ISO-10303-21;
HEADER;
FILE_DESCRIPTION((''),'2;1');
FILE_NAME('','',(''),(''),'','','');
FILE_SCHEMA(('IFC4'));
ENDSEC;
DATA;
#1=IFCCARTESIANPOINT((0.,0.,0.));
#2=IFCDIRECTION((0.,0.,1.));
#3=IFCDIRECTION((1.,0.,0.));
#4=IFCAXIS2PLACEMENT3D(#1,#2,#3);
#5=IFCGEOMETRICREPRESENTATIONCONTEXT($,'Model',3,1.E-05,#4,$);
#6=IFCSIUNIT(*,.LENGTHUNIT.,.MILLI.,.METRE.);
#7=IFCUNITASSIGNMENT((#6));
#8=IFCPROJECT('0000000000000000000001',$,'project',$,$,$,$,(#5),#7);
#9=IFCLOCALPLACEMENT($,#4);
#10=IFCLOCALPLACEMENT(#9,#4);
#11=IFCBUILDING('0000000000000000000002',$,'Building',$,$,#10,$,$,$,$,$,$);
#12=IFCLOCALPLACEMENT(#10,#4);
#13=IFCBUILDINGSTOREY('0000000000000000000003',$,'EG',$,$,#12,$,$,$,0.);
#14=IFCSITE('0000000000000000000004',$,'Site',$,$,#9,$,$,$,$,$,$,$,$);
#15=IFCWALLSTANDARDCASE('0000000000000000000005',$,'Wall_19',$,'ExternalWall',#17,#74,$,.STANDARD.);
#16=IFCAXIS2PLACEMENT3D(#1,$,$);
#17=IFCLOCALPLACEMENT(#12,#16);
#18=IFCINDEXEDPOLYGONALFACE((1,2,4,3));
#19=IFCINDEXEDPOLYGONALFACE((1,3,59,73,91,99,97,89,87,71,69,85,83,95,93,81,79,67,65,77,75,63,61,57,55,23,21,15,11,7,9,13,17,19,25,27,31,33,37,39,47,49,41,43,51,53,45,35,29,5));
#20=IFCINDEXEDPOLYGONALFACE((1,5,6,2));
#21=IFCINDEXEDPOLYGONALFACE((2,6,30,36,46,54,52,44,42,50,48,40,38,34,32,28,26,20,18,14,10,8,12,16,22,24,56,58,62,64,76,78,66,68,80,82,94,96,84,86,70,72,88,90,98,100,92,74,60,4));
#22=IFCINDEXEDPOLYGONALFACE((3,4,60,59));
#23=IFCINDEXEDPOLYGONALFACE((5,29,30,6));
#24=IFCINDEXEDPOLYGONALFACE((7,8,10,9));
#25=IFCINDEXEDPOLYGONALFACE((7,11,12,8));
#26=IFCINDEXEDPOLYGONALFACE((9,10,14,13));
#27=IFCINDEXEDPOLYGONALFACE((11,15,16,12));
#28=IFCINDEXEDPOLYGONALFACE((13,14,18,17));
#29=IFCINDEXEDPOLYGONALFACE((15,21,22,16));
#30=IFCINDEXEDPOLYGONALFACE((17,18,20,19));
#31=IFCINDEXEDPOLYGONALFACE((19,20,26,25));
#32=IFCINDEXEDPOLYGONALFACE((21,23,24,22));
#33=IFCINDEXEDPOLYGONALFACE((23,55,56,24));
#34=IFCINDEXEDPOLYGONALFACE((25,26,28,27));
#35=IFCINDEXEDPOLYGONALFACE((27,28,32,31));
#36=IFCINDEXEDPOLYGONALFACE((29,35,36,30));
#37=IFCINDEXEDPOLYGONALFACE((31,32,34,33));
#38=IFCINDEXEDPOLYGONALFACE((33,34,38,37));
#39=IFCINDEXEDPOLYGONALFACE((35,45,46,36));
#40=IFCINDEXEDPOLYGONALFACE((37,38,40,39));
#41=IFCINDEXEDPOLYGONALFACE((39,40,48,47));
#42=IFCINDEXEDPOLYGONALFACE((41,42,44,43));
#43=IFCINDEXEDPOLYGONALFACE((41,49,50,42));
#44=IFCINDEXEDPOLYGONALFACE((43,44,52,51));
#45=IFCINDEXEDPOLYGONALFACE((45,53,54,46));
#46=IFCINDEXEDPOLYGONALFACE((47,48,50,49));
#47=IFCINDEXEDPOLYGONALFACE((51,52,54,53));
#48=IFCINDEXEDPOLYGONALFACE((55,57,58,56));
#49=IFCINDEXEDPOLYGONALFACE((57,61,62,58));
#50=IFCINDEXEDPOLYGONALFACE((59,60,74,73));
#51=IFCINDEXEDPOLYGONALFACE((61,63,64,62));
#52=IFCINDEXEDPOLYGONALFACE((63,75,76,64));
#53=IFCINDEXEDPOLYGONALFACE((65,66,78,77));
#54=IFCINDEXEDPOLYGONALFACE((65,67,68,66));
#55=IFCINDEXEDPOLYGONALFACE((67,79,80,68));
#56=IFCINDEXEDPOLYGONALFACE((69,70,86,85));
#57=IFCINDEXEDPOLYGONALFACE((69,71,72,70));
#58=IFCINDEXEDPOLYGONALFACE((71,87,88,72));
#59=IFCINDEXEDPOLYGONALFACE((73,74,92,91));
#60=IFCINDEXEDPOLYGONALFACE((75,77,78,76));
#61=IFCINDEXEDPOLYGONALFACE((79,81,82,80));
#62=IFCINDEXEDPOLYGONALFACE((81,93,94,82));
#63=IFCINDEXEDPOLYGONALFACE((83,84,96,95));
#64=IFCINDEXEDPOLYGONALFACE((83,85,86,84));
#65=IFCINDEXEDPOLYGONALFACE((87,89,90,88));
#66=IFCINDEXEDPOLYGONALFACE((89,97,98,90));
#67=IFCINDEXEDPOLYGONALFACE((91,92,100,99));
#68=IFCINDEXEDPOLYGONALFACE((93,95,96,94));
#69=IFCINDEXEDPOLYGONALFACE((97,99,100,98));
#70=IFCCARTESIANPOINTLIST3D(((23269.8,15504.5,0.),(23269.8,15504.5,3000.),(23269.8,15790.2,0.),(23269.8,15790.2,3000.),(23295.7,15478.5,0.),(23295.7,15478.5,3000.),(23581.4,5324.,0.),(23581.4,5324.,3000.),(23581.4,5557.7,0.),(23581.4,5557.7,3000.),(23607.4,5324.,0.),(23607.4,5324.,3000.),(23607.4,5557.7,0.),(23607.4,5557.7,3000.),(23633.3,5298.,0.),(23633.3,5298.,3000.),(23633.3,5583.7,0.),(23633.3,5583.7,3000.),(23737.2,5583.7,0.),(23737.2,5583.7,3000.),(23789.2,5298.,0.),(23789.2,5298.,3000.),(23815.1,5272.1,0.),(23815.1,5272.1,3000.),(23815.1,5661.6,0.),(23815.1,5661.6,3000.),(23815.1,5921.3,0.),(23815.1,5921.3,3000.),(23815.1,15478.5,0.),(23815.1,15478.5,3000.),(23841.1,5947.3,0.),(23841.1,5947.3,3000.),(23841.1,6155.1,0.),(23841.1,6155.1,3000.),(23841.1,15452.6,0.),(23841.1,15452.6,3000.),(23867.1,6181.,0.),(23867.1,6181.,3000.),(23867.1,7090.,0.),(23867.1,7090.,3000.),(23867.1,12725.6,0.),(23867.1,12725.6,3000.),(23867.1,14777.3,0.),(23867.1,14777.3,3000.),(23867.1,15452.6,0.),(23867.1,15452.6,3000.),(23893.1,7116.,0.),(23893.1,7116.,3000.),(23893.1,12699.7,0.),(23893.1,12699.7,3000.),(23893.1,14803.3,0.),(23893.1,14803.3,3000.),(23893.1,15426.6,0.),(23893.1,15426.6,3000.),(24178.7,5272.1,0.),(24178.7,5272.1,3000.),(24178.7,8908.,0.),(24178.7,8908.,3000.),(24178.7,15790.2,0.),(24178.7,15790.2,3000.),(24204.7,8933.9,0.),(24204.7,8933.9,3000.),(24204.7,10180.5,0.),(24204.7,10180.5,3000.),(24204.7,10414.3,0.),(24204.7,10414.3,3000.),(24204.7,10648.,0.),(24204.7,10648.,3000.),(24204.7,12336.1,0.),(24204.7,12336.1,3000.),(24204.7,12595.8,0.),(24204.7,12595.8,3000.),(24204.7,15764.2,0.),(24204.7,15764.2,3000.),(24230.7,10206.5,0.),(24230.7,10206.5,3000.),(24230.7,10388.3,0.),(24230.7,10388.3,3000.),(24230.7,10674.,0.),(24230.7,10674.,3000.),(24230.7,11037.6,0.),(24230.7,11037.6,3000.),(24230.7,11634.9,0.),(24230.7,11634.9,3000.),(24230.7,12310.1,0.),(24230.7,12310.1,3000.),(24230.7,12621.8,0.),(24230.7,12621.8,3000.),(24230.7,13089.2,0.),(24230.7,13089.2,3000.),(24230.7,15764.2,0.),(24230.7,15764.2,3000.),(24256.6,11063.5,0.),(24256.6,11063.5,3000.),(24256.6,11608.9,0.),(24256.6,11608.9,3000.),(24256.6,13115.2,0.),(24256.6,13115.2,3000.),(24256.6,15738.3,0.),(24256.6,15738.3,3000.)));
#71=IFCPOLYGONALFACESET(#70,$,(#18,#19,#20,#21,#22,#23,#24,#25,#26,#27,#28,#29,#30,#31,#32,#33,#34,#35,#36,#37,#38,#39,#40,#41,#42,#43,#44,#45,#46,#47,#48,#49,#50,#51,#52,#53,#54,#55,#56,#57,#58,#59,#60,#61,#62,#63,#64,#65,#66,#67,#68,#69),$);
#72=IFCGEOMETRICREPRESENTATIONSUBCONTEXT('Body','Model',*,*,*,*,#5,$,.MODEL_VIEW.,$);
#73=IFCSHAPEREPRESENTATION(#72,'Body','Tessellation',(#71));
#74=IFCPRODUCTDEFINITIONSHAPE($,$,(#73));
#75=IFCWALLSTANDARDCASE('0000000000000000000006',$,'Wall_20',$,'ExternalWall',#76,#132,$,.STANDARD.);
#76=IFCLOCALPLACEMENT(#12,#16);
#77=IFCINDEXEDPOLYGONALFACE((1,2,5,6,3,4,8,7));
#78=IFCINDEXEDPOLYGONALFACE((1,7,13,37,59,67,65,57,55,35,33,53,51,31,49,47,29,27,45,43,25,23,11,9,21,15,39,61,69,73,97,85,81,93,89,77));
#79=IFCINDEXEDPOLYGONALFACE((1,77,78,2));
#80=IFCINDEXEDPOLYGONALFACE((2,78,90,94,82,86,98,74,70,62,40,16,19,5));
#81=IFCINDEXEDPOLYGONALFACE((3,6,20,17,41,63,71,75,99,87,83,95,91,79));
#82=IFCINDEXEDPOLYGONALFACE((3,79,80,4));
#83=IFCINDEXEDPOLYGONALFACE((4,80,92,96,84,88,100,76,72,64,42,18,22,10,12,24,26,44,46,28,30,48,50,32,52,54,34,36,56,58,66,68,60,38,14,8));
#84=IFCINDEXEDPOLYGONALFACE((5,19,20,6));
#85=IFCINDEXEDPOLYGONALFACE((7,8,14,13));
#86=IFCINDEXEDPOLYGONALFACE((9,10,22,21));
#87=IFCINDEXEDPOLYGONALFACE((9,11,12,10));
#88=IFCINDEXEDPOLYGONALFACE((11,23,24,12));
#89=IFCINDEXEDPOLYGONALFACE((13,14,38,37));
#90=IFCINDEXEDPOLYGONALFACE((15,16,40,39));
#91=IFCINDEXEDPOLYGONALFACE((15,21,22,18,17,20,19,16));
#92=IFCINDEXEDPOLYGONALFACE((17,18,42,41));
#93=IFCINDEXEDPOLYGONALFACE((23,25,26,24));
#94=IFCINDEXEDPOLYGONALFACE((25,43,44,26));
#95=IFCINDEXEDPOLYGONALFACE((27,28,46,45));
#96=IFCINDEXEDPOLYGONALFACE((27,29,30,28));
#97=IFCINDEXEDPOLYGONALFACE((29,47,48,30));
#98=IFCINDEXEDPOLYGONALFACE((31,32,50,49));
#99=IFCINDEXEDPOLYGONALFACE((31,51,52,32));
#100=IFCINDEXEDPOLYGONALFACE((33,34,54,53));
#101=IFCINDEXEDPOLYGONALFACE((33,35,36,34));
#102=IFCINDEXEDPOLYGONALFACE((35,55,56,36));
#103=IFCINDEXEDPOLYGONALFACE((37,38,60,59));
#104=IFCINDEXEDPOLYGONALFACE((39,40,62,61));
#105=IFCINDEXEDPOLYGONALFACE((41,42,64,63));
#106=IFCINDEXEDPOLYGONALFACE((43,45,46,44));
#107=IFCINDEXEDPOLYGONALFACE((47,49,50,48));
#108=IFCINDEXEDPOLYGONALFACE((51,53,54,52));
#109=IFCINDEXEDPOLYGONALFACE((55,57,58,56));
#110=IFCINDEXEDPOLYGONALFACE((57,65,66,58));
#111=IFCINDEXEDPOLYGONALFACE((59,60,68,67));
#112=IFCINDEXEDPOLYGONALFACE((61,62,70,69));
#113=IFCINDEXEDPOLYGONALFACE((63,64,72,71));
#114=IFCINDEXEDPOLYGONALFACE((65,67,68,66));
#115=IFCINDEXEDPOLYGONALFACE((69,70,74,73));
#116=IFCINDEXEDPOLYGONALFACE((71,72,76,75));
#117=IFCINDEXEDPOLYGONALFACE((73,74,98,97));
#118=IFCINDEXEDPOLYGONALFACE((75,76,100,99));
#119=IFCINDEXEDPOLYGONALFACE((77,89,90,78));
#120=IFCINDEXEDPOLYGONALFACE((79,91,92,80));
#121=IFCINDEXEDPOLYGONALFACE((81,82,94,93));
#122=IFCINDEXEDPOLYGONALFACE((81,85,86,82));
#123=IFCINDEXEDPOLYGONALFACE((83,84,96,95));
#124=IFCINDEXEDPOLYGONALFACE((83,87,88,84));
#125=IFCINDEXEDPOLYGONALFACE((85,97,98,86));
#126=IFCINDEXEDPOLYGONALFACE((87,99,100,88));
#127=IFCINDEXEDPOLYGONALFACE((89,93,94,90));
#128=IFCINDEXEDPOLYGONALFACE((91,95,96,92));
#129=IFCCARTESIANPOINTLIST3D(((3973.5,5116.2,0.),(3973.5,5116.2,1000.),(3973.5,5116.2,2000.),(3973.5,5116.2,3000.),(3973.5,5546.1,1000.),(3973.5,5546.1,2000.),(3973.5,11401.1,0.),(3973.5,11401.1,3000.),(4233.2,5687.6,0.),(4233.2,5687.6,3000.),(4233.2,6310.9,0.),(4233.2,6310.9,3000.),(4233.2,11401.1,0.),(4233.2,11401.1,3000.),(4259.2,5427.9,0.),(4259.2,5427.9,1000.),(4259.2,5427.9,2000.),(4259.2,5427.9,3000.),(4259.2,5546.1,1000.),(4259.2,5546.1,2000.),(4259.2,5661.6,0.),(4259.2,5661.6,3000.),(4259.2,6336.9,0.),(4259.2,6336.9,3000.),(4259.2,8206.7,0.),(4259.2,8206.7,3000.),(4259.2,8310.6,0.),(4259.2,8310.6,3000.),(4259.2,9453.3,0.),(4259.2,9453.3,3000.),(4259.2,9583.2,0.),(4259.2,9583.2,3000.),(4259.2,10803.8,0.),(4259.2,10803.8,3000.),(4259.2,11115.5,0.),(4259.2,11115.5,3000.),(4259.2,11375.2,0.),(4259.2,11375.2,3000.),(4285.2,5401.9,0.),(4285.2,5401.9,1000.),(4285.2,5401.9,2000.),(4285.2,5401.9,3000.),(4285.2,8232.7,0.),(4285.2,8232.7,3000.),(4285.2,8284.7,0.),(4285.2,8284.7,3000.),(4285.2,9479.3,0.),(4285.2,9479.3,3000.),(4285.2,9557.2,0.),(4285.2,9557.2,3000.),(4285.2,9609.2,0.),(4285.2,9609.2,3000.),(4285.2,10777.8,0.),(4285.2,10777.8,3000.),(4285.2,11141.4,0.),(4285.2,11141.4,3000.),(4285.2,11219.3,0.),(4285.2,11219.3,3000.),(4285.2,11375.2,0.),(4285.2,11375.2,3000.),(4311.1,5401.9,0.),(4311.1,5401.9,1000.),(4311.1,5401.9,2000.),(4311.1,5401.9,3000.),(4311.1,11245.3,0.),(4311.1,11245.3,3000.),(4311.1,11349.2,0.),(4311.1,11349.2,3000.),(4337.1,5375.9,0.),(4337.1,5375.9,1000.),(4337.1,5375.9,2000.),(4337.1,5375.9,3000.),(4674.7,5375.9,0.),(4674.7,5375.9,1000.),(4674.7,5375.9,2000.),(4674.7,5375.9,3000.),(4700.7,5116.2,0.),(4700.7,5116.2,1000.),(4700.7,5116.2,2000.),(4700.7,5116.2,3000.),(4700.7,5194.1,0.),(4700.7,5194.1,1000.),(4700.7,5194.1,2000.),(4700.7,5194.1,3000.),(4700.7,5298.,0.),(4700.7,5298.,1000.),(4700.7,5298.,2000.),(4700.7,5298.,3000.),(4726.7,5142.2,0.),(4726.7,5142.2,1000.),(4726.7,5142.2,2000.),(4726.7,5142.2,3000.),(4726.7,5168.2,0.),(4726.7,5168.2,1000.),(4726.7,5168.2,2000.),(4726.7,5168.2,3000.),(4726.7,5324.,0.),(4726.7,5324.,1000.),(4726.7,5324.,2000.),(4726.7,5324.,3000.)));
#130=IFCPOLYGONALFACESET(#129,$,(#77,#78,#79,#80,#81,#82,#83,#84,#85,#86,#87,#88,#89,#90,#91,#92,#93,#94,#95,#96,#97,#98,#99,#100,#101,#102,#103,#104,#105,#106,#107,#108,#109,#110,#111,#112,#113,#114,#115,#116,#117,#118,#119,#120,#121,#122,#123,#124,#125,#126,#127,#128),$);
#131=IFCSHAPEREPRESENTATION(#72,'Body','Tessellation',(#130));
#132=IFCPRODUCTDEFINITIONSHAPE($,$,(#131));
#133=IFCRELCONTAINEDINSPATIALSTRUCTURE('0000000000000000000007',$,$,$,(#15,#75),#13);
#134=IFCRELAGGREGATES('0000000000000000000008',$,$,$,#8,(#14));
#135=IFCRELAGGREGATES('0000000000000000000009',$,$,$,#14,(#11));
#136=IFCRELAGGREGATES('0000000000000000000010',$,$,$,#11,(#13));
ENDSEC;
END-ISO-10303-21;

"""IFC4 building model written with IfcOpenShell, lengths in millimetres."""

from ifc_helpers import new_model, si_unit, frame, origin_with_axes, place, context, subcontext, project, spatial, polyline, rectangle, outline, extrude, element, save


model = new_model("IFC4")

# Units and contexts
model_context = context("Model", 3, precision=1e-05, world=origin_with_axes())
body_context = subcontext(model_context, "Body", "Model", "MODEL_VIEW")
ifc_project = project(units=[si_unit("LENGTHUNIT", "METRE", prefix="MILLI")], contexts=[model_context])

# Site, building, storey
site_placement = place(None, origin_with_axes())
site = spatial("IfcSite", under=ifc_project, at=site_placement, Name="Site")
building_placement = place(site_placement, origin_with_axes())
building = spatial("IfcBuilding", under=site, at=building_placement, Name="Building")
storey_placement = place(building_placement, origin_with_axes())
storey = spatial("IfcBuildingStorey", under=building, at=storey_placement, Name="EG", Elevation=0.0)

# Wall
wall_1_placement = place(storey_placement, origin_with_axes())
element("IfcWallStandardCase", 1, at=wall_1_placement, inside=storey, Name="Wall_19", ObjectType="ExternalWall", PredefinedType="STANDARD", context=body_context, shape_type="SweptSolid", body=[
    extrude(outline(polyline([(23815.1, 5272.1, 0.0), (23789.2, 5298.0, 0.0), (23633.3, 5298.0, 0.0), (23607.4, 5324.0, 0.0), (23581.4, 5324.0, 0.0), (23581.4, 5557.7, 0.0), (23607.4, 5557.7, 0.0), (23633.3, 5583.7, 0.0), (23737.2, 5583.7, 0.0), (23815.1, 5661.6, 0.0), (23815.1, 5921.3, 0.0), (23841.1, 5947.3, 0.0), (23841.1, 6155.1, 0.0), (23867.1, 6181.0, 0.0), (23867.1, 7090.0, 0.0), (23893.1, 7116.0, 0.0), (23893.1, 12699.7, 0.0), (23867.1, 12725.6, 0.0), (23867.1, 14777.3, 0.0), (23893.1, 14803.3, 0.0), (23893.1, 15426.6, 0.0), (23867.1, 15452.6, 0.0), (23841.1, 15452.6, 0.0), (23815.1, 15478.5, 0.0), (23295.7, 15478.5, 0.0), (23269.8, 15504.5, 0.0), (23269.8, 15790.2, 0.0), (24178.7, 15790.2, 0.0), (24204.7, 15764.2, 0.0), (24230.7, 15764.2, 0.0), (24256.6, 15738.3, 0.0), (24256.6, 13115.2, 0.0), (24230.7, 13089.2, 0.0), (24230.7, 12621.8, 0.0), (24204.7, 12595.8, 0.0), (24204.7, 12336.1, 0.0), (24230.7, 12310.1, 0.0), (24230.7, 11634.9, 0.0), (24256.6, 11608.9, 0.0), (24256.6, 11063.5, 0.0), (24230.7, 11037.6, 0.0), (24230.7, 10674.0, 0.0), (24204.7, 10648.0, 0.0), (24204.7, 10414.3, 0.0), (24230.7, 10388.3, 0.0), (24230.7, 10206.5, 0.0), (24204.7, 10180.5, 0.0), (24204.7, 8933.9, 0.0), (24178.7, 8908.0, 0.0), (24178.7, 5272.1, 0.0), (23815.1, 5272.1, 0.0)])), origin_with_axes(), (0.0, 0.0, 1.0), 3000.0),
])

# Wall, opening
wall_2_placement = place(storey_placement, origin_with_axes())
wall_2 = element("IfcWallStandardCase", 2, at=wall_2_placement, inside=storey, Name="Wall_20", ObjectType="ExternalWall", PredefinedType="STANDARD", context=body_context, shape_type="SweptSolid", body=[
    extrude(outline(polyline([(3973.5, 5116.2, 0.0), (3973.5, 11401.1, 0.0), (4233.2, 11401.1, 0.0), (4259.2, 11375.2, 0.0), (4285.2, 11375.2, 0.0), (4311.1, 11349.2, 0.0), (4311.1, 11245.3, 0.0), (4285.2, 11219.3, 0.0), (4285.2, 11141.4, 0.0), (4259.2, 11115.5, 0.0), (4259.2, 10803.8, 0.0), (4285.2, 10777.8, 0.0), (4285.2, 9609.2, 0.0), (4259.2, 9583.2, 0.0), (4285.2, 9557.2, 0.0), (4285.2, 9479.3, 0.0), (4259.2, 9453.3, 0.0), (4259.2, 8310.6, 0.0), (4285.2, 8284.7, 0.0), (4285.2, 8232.7, 0.0), (4259.2, 8206.7, 0.0), (4259.2, 6336.9, 0.0), (4233.2, 6310.9, 0.0), (4233.2, 5687.6, 0.0), (4259.2, 5661.6, 0.0), (4259.2, 5427.9, 0.0), (4285.2, 5401.9, 0.0), (4311.1, 5401.9, 0.0), (4337.1, 5375.9, 0.0), (4674.7, 5375.9, 0.0), (4726.7, 5324.0, 0.0), (4700.7, 5298.0, 0.0), (4700.7, 5194.1, 0.0), (4726.7, 5168.2, 0.0), (4726.7, 5142.2, 0.0), (4700.7, 5116.2, 0.0), (3973.5, 5116.2, 0.0)])), origin_with_axes(), (0.0, 0.0, 1.0), 3000.0),
])
opening_1_placement = place(wall_2_placement, origin_with_axes())
element("IfcOpeningElement", 3, at=opening_1_placement, inside=storey, cuts=wall_2, context=body_context, shape_type="SweptSolid", body=[
    extrude(rectangle(XDim=600.0, YDim=753.2), frame((4350.1, 5246.1, 1000.0), z_axis=(0.0, 0.0, 1.0), x_axis=(0.0, 1.0, 0.0)), (0.0, 0.0, 1.0), 1000.0),
])

save(model, "model.ifc")
